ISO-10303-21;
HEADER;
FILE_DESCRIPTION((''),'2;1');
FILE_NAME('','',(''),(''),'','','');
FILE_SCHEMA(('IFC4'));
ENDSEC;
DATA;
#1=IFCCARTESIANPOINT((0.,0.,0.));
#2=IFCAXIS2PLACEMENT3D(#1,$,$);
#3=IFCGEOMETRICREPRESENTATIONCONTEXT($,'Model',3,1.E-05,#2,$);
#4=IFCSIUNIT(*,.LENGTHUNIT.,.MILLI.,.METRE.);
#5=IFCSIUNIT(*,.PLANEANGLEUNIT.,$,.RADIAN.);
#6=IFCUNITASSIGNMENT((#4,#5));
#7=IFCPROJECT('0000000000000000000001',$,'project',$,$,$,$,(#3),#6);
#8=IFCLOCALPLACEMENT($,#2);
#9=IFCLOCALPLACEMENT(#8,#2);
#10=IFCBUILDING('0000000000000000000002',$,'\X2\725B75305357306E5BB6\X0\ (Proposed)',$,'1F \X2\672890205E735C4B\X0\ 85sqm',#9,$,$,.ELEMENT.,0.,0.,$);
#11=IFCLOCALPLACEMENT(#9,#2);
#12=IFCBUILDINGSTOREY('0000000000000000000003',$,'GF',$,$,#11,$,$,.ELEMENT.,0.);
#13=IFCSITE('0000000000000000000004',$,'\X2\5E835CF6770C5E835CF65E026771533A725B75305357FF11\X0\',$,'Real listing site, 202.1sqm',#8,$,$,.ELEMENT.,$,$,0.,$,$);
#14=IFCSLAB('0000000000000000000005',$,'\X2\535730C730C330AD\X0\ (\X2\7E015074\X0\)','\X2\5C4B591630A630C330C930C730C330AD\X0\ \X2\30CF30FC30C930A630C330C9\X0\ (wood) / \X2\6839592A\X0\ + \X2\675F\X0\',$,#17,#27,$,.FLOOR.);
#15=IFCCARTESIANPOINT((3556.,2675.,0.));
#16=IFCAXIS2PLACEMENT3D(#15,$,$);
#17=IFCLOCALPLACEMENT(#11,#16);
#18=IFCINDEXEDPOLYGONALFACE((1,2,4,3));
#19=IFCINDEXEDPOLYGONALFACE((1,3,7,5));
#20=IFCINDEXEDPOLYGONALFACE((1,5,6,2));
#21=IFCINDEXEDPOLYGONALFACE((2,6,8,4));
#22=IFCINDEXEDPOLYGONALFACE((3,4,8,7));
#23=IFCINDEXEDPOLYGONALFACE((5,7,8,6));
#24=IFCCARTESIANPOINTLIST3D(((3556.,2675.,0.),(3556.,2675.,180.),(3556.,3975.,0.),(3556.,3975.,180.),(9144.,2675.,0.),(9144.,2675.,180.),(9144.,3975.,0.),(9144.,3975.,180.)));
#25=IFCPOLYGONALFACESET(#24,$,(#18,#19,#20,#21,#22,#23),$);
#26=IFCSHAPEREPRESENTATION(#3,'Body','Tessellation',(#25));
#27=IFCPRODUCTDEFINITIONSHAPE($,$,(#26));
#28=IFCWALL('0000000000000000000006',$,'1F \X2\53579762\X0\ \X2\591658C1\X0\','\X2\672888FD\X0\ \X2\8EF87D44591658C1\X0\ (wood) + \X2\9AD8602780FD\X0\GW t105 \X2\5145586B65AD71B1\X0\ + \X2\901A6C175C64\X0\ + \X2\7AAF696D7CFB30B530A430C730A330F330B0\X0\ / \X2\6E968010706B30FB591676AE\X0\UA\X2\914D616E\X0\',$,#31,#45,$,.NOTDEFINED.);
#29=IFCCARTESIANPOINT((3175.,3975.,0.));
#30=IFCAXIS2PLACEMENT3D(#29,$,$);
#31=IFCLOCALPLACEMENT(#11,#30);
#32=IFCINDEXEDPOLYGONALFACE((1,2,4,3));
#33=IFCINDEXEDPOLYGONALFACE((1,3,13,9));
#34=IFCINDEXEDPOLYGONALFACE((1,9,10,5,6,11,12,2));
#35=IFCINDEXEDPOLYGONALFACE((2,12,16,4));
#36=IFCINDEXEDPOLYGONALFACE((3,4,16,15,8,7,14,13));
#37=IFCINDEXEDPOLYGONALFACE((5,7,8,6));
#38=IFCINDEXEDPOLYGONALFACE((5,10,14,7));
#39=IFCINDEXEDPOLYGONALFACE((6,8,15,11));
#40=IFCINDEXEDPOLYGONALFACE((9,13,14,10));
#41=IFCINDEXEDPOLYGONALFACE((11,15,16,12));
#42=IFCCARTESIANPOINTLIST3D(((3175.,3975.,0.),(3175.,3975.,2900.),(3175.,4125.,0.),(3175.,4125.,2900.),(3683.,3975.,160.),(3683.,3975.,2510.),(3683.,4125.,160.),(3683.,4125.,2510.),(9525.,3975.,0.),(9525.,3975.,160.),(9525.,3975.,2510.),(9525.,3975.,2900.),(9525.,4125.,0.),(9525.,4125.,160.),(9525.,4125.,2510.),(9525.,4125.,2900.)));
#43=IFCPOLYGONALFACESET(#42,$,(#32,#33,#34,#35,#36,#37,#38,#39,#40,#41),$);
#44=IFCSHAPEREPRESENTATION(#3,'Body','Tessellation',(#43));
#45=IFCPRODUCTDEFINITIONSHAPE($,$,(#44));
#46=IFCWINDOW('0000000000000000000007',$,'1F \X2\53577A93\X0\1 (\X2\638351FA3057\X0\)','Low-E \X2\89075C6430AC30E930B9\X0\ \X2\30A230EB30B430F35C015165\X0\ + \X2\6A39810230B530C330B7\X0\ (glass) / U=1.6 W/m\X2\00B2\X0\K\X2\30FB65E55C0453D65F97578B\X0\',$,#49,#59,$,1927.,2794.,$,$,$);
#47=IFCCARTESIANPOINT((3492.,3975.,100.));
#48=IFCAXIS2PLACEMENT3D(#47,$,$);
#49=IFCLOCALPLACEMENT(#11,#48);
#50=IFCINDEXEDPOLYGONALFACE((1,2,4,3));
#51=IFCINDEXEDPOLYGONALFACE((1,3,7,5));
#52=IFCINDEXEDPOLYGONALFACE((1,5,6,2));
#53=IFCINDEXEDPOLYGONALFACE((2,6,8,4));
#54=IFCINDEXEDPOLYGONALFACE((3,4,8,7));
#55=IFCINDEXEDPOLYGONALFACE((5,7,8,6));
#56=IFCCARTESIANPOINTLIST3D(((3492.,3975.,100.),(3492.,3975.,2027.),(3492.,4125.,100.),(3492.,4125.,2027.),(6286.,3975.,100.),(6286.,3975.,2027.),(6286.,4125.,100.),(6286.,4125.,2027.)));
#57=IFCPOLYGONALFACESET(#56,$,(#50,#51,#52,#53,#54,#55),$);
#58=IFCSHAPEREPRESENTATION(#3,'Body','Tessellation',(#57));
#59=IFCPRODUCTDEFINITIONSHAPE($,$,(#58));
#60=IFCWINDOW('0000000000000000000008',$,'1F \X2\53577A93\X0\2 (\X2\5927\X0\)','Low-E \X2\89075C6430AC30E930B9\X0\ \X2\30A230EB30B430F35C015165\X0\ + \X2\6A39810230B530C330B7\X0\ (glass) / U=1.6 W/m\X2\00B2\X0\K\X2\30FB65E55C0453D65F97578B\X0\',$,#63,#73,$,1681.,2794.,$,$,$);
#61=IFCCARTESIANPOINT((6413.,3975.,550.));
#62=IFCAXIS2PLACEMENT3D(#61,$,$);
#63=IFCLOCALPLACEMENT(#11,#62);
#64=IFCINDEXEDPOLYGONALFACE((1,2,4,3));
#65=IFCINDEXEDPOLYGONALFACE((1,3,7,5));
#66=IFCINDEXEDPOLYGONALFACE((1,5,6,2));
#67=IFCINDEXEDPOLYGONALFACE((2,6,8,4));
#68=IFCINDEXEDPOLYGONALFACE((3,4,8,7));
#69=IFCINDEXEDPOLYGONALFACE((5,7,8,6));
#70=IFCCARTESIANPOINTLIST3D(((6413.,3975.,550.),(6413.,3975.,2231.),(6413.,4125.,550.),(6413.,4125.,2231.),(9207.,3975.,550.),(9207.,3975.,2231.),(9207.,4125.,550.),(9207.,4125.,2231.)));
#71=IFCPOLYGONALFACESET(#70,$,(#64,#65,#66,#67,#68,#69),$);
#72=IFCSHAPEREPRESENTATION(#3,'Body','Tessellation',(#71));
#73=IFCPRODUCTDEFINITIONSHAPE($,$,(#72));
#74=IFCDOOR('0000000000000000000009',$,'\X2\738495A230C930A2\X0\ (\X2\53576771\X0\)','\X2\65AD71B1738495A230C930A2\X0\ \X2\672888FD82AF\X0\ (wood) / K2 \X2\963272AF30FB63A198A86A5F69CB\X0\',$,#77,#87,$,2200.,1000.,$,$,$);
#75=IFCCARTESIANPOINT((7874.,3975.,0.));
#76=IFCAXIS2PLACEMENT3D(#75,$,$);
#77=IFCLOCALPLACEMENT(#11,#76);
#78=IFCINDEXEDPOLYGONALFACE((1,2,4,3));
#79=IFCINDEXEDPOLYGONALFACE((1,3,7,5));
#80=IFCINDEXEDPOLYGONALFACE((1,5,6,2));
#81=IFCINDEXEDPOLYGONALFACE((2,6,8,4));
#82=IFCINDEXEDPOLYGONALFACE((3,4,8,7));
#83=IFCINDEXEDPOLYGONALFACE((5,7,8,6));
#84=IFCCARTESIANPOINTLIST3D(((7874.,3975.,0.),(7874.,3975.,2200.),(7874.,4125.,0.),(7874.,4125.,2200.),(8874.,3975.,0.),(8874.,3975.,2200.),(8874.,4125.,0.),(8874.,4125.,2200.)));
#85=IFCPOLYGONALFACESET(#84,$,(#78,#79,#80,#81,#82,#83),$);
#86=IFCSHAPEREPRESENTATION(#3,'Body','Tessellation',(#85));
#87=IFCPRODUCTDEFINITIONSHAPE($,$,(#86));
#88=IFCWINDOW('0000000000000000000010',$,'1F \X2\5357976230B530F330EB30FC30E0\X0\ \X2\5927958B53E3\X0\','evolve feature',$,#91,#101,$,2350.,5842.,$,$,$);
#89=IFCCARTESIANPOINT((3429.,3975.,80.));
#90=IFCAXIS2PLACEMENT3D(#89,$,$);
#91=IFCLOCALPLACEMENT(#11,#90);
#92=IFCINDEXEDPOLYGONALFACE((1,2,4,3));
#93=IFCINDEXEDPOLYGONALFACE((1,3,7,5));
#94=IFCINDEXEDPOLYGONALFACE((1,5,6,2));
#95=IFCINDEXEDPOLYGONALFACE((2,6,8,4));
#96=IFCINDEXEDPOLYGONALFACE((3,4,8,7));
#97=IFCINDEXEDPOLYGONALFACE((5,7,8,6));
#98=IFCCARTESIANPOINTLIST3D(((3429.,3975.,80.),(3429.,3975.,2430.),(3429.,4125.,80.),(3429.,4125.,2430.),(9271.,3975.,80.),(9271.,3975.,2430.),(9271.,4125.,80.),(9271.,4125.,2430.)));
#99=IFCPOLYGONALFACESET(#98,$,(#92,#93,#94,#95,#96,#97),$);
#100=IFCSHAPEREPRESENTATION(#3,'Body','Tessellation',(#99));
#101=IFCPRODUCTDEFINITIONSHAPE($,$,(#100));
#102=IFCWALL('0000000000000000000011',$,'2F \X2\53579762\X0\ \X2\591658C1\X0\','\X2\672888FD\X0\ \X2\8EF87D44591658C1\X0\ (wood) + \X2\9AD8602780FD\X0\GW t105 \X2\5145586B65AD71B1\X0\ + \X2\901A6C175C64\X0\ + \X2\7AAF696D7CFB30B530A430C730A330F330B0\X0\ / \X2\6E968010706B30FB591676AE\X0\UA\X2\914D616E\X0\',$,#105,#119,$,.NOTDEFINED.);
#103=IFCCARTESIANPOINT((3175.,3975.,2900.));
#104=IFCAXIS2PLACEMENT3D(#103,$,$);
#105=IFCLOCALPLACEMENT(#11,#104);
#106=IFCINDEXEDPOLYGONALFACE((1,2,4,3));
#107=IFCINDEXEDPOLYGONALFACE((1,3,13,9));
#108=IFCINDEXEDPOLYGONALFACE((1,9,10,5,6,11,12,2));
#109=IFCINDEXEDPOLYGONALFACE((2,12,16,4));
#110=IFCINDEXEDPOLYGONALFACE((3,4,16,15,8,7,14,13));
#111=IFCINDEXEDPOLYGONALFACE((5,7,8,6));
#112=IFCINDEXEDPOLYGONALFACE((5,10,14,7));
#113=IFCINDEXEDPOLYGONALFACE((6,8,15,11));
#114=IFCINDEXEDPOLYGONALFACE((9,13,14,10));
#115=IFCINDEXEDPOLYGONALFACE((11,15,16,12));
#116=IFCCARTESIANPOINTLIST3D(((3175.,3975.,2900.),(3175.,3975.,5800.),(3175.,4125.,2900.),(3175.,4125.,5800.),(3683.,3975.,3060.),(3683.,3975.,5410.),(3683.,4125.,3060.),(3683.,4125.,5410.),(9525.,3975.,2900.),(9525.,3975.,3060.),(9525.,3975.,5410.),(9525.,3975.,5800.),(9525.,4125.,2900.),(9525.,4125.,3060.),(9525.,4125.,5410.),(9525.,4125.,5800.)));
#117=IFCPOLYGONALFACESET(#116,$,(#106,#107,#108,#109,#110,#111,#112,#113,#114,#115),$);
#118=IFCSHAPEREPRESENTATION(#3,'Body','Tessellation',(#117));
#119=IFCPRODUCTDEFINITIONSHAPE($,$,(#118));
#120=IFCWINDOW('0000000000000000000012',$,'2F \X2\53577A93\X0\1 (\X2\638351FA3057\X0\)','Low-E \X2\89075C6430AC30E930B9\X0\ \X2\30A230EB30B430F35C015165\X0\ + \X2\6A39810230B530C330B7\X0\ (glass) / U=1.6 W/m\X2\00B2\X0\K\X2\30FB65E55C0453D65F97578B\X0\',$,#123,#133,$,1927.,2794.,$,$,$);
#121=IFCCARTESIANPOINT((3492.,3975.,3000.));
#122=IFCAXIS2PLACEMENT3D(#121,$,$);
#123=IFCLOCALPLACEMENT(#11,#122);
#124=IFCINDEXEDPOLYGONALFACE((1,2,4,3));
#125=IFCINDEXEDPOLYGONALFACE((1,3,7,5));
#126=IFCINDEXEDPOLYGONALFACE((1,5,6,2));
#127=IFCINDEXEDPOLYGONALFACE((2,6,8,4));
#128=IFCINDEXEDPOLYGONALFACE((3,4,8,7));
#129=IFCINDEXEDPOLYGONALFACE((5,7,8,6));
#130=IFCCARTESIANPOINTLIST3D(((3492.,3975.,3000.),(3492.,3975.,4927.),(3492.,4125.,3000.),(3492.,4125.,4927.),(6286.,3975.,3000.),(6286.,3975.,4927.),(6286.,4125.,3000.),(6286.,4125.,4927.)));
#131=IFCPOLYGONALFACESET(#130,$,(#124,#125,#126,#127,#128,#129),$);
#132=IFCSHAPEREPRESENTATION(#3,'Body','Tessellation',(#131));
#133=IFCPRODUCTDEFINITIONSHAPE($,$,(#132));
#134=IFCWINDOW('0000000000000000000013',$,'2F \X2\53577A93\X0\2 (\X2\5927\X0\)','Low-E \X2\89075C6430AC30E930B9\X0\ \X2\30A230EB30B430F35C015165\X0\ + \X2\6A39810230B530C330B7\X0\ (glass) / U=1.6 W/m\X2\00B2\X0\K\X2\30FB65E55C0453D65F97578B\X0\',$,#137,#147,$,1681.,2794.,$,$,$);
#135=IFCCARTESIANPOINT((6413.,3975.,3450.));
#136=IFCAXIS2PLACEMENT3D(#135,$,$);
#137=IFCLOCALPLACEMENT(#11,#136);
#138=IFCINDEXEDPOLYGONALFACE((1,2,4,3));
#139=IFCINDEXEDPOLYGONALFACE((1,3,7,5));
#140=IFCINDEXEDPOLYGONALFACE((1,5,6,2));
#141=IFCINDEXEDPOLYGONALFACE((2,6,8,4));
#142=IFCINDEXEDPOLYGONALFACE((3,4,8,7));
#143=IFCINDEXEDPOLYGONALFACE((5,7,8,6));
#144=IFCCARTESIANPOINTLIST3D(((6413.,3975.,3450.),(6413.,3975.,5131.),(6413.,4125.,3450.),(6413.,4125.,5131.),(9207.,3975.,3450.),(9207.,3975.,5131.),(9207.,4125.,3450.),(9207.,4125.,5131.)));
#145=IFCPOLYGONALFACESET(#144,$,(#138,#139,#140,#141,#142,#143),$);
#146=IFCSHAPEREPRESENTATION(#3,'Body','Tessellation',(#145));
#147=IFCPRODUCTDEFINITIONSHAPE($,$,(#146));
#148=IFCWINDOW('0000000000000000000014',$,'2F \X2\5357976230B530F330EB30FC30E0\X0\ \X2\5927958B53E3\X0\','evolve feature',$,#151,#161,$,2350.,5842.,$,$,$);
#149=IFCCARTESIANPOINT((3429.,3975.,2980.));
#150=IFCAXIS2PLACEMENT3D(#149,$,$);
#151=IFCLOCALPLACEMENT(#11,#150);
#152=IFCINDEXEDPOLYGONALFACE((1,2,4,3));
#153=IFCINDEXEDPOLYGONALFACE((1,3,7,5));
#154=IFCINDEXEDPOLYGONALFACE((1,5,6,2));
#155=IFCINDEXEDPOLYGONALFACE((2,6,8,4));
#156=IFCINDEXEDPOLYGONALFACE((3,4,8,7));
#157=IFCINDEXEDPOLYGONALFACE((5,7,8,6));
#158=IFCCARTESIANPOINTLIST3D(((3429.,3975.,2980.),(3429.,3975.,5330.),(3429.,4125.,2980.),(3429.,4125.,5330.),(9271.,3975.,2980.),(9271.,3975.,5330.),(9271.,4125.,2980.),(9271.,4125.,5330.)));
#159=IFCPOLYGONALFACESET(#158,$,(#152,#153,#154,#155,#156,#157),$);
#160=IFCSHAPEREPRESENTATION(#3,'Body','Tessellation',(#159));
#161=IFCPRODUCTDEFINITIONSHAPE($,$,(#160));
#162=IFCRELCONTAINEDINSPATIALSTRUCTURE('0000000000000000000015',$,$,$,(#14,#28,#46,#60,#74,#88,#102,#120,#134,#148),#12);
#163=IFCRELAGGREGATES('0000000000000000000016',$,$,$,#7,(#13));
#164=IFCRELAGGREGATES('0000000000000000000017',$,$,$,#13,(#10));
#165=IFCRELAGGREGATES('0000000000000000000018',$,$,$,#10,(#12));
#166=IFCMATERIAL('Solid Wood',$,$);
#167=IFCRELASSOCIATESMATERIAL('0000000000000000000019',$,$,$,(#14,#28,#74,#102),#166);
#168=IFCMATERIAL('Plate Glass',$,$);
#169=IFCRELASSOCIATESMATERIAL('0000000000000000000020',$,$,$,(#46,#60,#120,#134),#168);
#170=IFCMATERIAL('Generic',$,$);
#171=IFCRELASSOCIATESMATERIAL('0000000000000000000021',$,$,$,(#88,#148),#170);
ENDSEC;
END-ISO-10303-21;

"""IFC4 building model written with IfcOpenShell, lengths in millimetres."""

from ifc_helpers import new_model, si_unit, frame, frame_2d, origin, place, context, project, spatial, rectangle, extrude, material, element, fill, save


model = new_model("IFC4")

# Units and contexts
model_context = context("Model", 3, precision=1e-05, world=origin())
ifc_project = project(units=[si_unit("LENGTHUNIT", "METRE", prefix="MILLI"), si_unit("PLANEANGLEUNIT", "RADIAN")], contexts=[model_context])

# Site, building, storey
site_placement = place(None, origin())
site = spatial("IfcSite", under=ifc_project, at=site_placement, Name="広島県広島市東区牛田南１", ObjectType="Real listing site, 202.1sqm", CompositionType="ELEMENT", RefElevation=0.0)
building_placement = place(site_placement, origin())
building = spatial("IfcBuilding", under=site, at=building_placement, Name="牛田南の家 (Proposed)", ObjectType="1F 木造平屋 85sqm", CompositionType="ELEMENT", ElevationOfRefHeight=0.0, ElevationOfTerrain=0.0)
storey_placement = place(building_placement, origin())
storey = spatial("IfcBuildingStorey", under=building, at=storey_placement, Name="GF", CompositionType="ELEMENT", Elevation=0.0)

# Slab
ifc_material_1 = material(Name="Solid Wood")
slab_1_placement = place(storey_placement, frame((3556.0, 2675.0, 0.0)))
element("IfcSlab", 1, at=slab_1_placement, inside=storey, material=ifc_material_1, Name="南デッキ (縁側)", Description="屋外ウッドデッキ ハードウッド (wood) / 根太 + 束", PredefinedType="FLOOR", context=model_context, shape_type="SweptSolid", body=[
    extrude(rectangle(XDim=5588.0, YDim=1300.0, at=frame_2d((2794.0, 650.0))), frame((3556.0, 2675.0, 0.0)), (0.0, 0.0, 1.0), 180.0),
])
ifc_material_2 = material(Name="Generic")

# Wall, openings, windows, door
wall_1_placement = place(storey_placement, frame((3175.0, 3975.0, 0.0)))
wall_1 = element("IfcWall", 2, at=wall_1_placement, inside=storey, material=ifc_material_1, Name="1F 南面 外壁", Description="木製 軸組外壁 (wood) + 高性能GW t105 充填断熱 + 通気層 + 窯業系サイディング / 準耐火・外皮UA配慮", PredefinedType="NOTDEFINED", context=model_context, shape_type="SweptSolid", body=[
    extrude(rectangle(XDim=6350.0, YDim=150.0, at=frame_2d((3175.0, 75.0))), frame((3175.0, 3975.0, 0.0)), (0.0, 0.0, 1.0), 2900.0),
])
opening_1_placement = place(storey_placement, frame((3492.0, 3975.0, 100.0)))
opening_1 = element("IfcOpeningElement", 3, at=opening_1_placement, cuts=wall_1, PredefinedType="NOTDEFINED", context=model_context, shape_type="SweptSolid", body=[
    extrude(rectangle(XDim=2794.0, YDim=150.0, at=frame_2d((1397.0, 75.0))), frame((3492.0, 3975.0, 100.0)), (0.0, 0.0, 1.0), 1927.0),
])
opening_2_placement = place(storey_placement, frame((6413.0, 3975.0, 550.0)))
opening_2 = element("IfcOpeningElement", 4, at=opening_2_placement, cuts=wall_1, PredefinedType="NOTDEFINED", context=model_context, shape_type="SweptSolid", body=[
    extrude(rectangle(XDim=2794.0, YDim=150.0, at=frame_2d((1397.0, 75.0))), frame((6413.0, 3975.0, 550.0)), (0.0, 0.0, 1.0), 1681.0),
])
opening_3_placement = place(storey_placement, frame((7874.0, 3975.0, 0.0)))
opening_3 = element("IfcOpeningElement", 5, at=opening_3_placement, cuts=wall_1, PredefinedType="NOTDEFINED", context=model_context, shape_type="SweptSolid", body=[
    extrude(rectangle(XDim=1000.0, YDim=150.0, at=frame_2d((500.0, 75.0))), frame((7874.0, 3975.0, 0.0)), (0.0, 0.0, 1.0), 2200.0),
])
opening_4_placement = place(storey_placement, frame((3429.0, 3975.0, 80.0)))
opening_4 = element("IfcOpeningElement", 6, at=opening_4_placement, cuts=wall_1, PredefinedType="NOTDEFINED", context=model_context, shape_type="SweptSolid", body=[
    extrude(rectangle(XDim=5842.0, YDim=150.0, at=frame_2d((2921.0, 75.0))), frame((3429.0, 3975.0, 80.0)), (0.0, 0.0, 1.0), 2350.0),
])
ifc_material_3 = material(Name="Plate Glass")
window_1_placement = place(storey_placement, frame((3492.0, 3975.0, 100.0)))
window_1 = element("IfcWindow", 7, at=window_1_placement, inside=storey, material=ifc_material_3, Name="1F 南窓1 (掃出し)", Description="Low-E 複層ガラス アルゴン封入 + 樹脂サッシ (glass) / U=1.6 W/m²K・日射取得型", OverallHeight=1927.0, OverallWidth=2794.0, context=model_context, shape_type="SweptSolid", body=[
    extrude(rectangle(XDim=2794.0, YDim=150.0, at=frame_2d((1397.0, 75.0))), frame((3492.0, 3975.0, 100.0)), (0.0, 0.0, 1.0), 1927.0),
])
fill(opening_1, window_1)
window_2_placement = place(storey_placement, frame((6413.0, 3975.0, 550.0)))
window_2 = element("IfcWindow", 8, at=window_2_placement, inside=storey, material=ifc_material_3, Name="1F 南窓2 (大)", Description="Low-E 複層ガラス アルゴン封入 + 樹脂サッシ (glass) / U=1.6 W/m²K・日射取得型", OverallHeight=1681.0, OverallWidth=2794.0, context=model_context, shape_type="SweptSolid", body=[
    extrude(rectangle(XDim=2794.0, YDim=150.0, at=frame_2d((1397.0, 75.0))), frame((6413.0, 3975.0, 550.0)), (0.0, 0.0, 1.0), 1681.0),
])
fill(opening_2, window_2)
door_placement = place(storey_placement, frame((7874.0, 3975.0, 0.0)))
door = element("IfcDoor", 9, at=door_placement, inside=storey, material=ifc_material_1, Name="玄関ドア (南東)", Description="断熱玄関ドア 木製芯 (wood) / K2 防犯・採風機構", OverallHeight=2200.0, OverallWidth=1000.0, context=model_context, shape_type="SweptSolid", body=[
    extrude(rectangle(XDim=1000.0, YDim=150.0, at=frame_2d((500.0, 75.0))), frame((7874.0, 3975.0, 0.0)), (0.0, 0.0, 1.0), 2200.0),
])
fill(opening_3, door)
window_3_placement = place(storey_placement, frame((3429.0, 3975.0, 80.0)))
window_3 = element("IfcWindow", 10, at=window_3_placement, inside=storey, material=ifc_material_2, Name="1F 南面サンルーム 大開口", Description="evolve feature", OverallHeight=2350.0, OverallWidth=5842.0, context=model_context, shape_type="SweptSolid", body=[
    extrude(rectangle(XDim=5842.0, YDim=150.0, at=frame_2d((2921.0, 75.0))), frame((3429.0, 3975.0, 80.0)), (0.0, 0.0, 1.0), 2350.0),
])
fill(opening_4, window_3)

# Wall, openings, windows
wall_2_placement = place(storey_placement, frame((3175.0, 3975.0, 2900.0)))
wall_2 = element("IfcWall", 11, at=wall_2_placement, inside=storey, material=ifc_material_1, Name="2F 南面 外壁", Description="木製 軸組外壁 (wood) + 高性能GW t105 充填断熱 + 通気層 + 窯業系サイディング / 準耐火・外皮UA配慮", PredefinedType="NOTDEFINED", context=model_context, shape_type="SweptSolid", body=[
    extrude(rectangle(XDim=6350.0, YDim=150.0, at=frame_2d((3175.0, 75.0))), frame((3175.0, 3975.0, 2900.0)), (0.0, 0.0, 1.0), 2900.0),
])
opening_5_placement = place(storey_placement, frame((3492.0, 3975.0, 3000.0)))
opening_5 = element("IfcOpeningElement", 12, at=opening_5_placement, cuts=wall_2, PredefinedType="NOTDEFINED", context=model_context, shape_type="SweptSolid", body=[
    extrude(rectangle(XDim=2794.0, YDim=150.0, at=frame_2d((1397.0, 75.0))), frame((3492.0, 3975.0, 3000.0)), (0.0, 0.0, 1.0), 1927.0),
])
opening_6_placement = place(storey_placement, frame((6413.0, 3975.0, 3450.0)))
opening_6 = element("IfcOpeningElement", 13, at=opening_6_placement, cuts=wall_2, PredefinedType="NOTDEFINED", context=model_context, shape_type="SweptSolid", body=[
    extrude(rectangle(XDim=2794.0, YDim=150.0, at=frame_2d((1397.0, 75.0))), frame((6413.0, 3975.0, 3450.0)), (0.0, 0.0, 1.0), 1681.0),
])
opening_7_placement = place(storey_placement, frame((3429.0, 3975.0, 2980.0)))
opening_7 = element("IfcOpeningElement", 14, at=opening_7_placement, cuts=wall_2, PredefinedType="NOTDEFINED", context=model_context, shape_type="SweptSolid", body=[
    extrude(rectangle(XDim=5842.0, YDim=150.0, at=frame_2d((2921.0, 75.0))), frame((3429.0, 3975.0, 2980.0)), (0.0, 0.0, 1.0), 2350.0),
])
window_4_placement = place(storey_placement, frame((3492.0, 3975.0, 3000.0)))
window_4 = element("IfcWindow", 15, at=window_4_placement, inside=storey, material=ifc_material_3, Name="2F 南窓1 (掃出し)", Description="Low-E 複層ガラス アルゴン封入 + 樹脂サッシ (glass) / U=1.6 W/m²K・日射取得型", OverallHeight=1927.0, OverallWidth=2794.0, context=model_context, shape_type="SweptSolid", body=[
    extrude(rectangle(XDim=2794.0, YDim=150.0, at=frame_2d((1397.0, 75.0))), frame((3492.0, 3975.0, 3000.0)), (0.0, 0.0, 1.0), 1927.0),
])
fill(opening_5, window_4)
window_5_placement = place(storey_placement, frame((6413.0, 3975.0, 3450.0)))
window_5 = element("IfcWindow", 16, at=window_5_placement, inside=storey, material=ifc_material_3, Name="2F 南窓2 (大)", Description="Low-E 複層ガラス アルゴン封入 + 樹脂サッシ (glass) / U=1.6 W/m²K・日射取得型", OverallHeight=1681.0, OverallWidth=2794.0, context=model_context, shape_type="SweptSolid", body=[
    extrude(rectangle(XDim=2794.0, YDim=150.0, at=frame_2d((1397.0, 75.0))), frame((6413.0, 3975.0, 3450.0)), (0.0, 0.0, 1.0), 1681.0),
])
fill(opening_6, window_5)
window_6_placement = place(storey_placement, frame((3429.0, 3975.0, 2980.0)))
window_6 = element("IfcWindow", 17, at=window_6_placement, inside=storey, material=ifc_material_2, Name="2F 南面サンルーム 大開口", Description="evolve feature", OverallHeight=2350.0, OverallWidth=5842.0, context=model_context, shape_type="SweptSolid", body=[
    extrude(rectangle(XDim=5842.0, YDim=150.0, at=frame_2d((2921.0, 75.0))), frame((3429.0, 3975.0, 2980.0)), (0.0, 0.0, 1.0), 2350.0),
])
fill(opening_7, window_6)

save(model, "model.ifc")
